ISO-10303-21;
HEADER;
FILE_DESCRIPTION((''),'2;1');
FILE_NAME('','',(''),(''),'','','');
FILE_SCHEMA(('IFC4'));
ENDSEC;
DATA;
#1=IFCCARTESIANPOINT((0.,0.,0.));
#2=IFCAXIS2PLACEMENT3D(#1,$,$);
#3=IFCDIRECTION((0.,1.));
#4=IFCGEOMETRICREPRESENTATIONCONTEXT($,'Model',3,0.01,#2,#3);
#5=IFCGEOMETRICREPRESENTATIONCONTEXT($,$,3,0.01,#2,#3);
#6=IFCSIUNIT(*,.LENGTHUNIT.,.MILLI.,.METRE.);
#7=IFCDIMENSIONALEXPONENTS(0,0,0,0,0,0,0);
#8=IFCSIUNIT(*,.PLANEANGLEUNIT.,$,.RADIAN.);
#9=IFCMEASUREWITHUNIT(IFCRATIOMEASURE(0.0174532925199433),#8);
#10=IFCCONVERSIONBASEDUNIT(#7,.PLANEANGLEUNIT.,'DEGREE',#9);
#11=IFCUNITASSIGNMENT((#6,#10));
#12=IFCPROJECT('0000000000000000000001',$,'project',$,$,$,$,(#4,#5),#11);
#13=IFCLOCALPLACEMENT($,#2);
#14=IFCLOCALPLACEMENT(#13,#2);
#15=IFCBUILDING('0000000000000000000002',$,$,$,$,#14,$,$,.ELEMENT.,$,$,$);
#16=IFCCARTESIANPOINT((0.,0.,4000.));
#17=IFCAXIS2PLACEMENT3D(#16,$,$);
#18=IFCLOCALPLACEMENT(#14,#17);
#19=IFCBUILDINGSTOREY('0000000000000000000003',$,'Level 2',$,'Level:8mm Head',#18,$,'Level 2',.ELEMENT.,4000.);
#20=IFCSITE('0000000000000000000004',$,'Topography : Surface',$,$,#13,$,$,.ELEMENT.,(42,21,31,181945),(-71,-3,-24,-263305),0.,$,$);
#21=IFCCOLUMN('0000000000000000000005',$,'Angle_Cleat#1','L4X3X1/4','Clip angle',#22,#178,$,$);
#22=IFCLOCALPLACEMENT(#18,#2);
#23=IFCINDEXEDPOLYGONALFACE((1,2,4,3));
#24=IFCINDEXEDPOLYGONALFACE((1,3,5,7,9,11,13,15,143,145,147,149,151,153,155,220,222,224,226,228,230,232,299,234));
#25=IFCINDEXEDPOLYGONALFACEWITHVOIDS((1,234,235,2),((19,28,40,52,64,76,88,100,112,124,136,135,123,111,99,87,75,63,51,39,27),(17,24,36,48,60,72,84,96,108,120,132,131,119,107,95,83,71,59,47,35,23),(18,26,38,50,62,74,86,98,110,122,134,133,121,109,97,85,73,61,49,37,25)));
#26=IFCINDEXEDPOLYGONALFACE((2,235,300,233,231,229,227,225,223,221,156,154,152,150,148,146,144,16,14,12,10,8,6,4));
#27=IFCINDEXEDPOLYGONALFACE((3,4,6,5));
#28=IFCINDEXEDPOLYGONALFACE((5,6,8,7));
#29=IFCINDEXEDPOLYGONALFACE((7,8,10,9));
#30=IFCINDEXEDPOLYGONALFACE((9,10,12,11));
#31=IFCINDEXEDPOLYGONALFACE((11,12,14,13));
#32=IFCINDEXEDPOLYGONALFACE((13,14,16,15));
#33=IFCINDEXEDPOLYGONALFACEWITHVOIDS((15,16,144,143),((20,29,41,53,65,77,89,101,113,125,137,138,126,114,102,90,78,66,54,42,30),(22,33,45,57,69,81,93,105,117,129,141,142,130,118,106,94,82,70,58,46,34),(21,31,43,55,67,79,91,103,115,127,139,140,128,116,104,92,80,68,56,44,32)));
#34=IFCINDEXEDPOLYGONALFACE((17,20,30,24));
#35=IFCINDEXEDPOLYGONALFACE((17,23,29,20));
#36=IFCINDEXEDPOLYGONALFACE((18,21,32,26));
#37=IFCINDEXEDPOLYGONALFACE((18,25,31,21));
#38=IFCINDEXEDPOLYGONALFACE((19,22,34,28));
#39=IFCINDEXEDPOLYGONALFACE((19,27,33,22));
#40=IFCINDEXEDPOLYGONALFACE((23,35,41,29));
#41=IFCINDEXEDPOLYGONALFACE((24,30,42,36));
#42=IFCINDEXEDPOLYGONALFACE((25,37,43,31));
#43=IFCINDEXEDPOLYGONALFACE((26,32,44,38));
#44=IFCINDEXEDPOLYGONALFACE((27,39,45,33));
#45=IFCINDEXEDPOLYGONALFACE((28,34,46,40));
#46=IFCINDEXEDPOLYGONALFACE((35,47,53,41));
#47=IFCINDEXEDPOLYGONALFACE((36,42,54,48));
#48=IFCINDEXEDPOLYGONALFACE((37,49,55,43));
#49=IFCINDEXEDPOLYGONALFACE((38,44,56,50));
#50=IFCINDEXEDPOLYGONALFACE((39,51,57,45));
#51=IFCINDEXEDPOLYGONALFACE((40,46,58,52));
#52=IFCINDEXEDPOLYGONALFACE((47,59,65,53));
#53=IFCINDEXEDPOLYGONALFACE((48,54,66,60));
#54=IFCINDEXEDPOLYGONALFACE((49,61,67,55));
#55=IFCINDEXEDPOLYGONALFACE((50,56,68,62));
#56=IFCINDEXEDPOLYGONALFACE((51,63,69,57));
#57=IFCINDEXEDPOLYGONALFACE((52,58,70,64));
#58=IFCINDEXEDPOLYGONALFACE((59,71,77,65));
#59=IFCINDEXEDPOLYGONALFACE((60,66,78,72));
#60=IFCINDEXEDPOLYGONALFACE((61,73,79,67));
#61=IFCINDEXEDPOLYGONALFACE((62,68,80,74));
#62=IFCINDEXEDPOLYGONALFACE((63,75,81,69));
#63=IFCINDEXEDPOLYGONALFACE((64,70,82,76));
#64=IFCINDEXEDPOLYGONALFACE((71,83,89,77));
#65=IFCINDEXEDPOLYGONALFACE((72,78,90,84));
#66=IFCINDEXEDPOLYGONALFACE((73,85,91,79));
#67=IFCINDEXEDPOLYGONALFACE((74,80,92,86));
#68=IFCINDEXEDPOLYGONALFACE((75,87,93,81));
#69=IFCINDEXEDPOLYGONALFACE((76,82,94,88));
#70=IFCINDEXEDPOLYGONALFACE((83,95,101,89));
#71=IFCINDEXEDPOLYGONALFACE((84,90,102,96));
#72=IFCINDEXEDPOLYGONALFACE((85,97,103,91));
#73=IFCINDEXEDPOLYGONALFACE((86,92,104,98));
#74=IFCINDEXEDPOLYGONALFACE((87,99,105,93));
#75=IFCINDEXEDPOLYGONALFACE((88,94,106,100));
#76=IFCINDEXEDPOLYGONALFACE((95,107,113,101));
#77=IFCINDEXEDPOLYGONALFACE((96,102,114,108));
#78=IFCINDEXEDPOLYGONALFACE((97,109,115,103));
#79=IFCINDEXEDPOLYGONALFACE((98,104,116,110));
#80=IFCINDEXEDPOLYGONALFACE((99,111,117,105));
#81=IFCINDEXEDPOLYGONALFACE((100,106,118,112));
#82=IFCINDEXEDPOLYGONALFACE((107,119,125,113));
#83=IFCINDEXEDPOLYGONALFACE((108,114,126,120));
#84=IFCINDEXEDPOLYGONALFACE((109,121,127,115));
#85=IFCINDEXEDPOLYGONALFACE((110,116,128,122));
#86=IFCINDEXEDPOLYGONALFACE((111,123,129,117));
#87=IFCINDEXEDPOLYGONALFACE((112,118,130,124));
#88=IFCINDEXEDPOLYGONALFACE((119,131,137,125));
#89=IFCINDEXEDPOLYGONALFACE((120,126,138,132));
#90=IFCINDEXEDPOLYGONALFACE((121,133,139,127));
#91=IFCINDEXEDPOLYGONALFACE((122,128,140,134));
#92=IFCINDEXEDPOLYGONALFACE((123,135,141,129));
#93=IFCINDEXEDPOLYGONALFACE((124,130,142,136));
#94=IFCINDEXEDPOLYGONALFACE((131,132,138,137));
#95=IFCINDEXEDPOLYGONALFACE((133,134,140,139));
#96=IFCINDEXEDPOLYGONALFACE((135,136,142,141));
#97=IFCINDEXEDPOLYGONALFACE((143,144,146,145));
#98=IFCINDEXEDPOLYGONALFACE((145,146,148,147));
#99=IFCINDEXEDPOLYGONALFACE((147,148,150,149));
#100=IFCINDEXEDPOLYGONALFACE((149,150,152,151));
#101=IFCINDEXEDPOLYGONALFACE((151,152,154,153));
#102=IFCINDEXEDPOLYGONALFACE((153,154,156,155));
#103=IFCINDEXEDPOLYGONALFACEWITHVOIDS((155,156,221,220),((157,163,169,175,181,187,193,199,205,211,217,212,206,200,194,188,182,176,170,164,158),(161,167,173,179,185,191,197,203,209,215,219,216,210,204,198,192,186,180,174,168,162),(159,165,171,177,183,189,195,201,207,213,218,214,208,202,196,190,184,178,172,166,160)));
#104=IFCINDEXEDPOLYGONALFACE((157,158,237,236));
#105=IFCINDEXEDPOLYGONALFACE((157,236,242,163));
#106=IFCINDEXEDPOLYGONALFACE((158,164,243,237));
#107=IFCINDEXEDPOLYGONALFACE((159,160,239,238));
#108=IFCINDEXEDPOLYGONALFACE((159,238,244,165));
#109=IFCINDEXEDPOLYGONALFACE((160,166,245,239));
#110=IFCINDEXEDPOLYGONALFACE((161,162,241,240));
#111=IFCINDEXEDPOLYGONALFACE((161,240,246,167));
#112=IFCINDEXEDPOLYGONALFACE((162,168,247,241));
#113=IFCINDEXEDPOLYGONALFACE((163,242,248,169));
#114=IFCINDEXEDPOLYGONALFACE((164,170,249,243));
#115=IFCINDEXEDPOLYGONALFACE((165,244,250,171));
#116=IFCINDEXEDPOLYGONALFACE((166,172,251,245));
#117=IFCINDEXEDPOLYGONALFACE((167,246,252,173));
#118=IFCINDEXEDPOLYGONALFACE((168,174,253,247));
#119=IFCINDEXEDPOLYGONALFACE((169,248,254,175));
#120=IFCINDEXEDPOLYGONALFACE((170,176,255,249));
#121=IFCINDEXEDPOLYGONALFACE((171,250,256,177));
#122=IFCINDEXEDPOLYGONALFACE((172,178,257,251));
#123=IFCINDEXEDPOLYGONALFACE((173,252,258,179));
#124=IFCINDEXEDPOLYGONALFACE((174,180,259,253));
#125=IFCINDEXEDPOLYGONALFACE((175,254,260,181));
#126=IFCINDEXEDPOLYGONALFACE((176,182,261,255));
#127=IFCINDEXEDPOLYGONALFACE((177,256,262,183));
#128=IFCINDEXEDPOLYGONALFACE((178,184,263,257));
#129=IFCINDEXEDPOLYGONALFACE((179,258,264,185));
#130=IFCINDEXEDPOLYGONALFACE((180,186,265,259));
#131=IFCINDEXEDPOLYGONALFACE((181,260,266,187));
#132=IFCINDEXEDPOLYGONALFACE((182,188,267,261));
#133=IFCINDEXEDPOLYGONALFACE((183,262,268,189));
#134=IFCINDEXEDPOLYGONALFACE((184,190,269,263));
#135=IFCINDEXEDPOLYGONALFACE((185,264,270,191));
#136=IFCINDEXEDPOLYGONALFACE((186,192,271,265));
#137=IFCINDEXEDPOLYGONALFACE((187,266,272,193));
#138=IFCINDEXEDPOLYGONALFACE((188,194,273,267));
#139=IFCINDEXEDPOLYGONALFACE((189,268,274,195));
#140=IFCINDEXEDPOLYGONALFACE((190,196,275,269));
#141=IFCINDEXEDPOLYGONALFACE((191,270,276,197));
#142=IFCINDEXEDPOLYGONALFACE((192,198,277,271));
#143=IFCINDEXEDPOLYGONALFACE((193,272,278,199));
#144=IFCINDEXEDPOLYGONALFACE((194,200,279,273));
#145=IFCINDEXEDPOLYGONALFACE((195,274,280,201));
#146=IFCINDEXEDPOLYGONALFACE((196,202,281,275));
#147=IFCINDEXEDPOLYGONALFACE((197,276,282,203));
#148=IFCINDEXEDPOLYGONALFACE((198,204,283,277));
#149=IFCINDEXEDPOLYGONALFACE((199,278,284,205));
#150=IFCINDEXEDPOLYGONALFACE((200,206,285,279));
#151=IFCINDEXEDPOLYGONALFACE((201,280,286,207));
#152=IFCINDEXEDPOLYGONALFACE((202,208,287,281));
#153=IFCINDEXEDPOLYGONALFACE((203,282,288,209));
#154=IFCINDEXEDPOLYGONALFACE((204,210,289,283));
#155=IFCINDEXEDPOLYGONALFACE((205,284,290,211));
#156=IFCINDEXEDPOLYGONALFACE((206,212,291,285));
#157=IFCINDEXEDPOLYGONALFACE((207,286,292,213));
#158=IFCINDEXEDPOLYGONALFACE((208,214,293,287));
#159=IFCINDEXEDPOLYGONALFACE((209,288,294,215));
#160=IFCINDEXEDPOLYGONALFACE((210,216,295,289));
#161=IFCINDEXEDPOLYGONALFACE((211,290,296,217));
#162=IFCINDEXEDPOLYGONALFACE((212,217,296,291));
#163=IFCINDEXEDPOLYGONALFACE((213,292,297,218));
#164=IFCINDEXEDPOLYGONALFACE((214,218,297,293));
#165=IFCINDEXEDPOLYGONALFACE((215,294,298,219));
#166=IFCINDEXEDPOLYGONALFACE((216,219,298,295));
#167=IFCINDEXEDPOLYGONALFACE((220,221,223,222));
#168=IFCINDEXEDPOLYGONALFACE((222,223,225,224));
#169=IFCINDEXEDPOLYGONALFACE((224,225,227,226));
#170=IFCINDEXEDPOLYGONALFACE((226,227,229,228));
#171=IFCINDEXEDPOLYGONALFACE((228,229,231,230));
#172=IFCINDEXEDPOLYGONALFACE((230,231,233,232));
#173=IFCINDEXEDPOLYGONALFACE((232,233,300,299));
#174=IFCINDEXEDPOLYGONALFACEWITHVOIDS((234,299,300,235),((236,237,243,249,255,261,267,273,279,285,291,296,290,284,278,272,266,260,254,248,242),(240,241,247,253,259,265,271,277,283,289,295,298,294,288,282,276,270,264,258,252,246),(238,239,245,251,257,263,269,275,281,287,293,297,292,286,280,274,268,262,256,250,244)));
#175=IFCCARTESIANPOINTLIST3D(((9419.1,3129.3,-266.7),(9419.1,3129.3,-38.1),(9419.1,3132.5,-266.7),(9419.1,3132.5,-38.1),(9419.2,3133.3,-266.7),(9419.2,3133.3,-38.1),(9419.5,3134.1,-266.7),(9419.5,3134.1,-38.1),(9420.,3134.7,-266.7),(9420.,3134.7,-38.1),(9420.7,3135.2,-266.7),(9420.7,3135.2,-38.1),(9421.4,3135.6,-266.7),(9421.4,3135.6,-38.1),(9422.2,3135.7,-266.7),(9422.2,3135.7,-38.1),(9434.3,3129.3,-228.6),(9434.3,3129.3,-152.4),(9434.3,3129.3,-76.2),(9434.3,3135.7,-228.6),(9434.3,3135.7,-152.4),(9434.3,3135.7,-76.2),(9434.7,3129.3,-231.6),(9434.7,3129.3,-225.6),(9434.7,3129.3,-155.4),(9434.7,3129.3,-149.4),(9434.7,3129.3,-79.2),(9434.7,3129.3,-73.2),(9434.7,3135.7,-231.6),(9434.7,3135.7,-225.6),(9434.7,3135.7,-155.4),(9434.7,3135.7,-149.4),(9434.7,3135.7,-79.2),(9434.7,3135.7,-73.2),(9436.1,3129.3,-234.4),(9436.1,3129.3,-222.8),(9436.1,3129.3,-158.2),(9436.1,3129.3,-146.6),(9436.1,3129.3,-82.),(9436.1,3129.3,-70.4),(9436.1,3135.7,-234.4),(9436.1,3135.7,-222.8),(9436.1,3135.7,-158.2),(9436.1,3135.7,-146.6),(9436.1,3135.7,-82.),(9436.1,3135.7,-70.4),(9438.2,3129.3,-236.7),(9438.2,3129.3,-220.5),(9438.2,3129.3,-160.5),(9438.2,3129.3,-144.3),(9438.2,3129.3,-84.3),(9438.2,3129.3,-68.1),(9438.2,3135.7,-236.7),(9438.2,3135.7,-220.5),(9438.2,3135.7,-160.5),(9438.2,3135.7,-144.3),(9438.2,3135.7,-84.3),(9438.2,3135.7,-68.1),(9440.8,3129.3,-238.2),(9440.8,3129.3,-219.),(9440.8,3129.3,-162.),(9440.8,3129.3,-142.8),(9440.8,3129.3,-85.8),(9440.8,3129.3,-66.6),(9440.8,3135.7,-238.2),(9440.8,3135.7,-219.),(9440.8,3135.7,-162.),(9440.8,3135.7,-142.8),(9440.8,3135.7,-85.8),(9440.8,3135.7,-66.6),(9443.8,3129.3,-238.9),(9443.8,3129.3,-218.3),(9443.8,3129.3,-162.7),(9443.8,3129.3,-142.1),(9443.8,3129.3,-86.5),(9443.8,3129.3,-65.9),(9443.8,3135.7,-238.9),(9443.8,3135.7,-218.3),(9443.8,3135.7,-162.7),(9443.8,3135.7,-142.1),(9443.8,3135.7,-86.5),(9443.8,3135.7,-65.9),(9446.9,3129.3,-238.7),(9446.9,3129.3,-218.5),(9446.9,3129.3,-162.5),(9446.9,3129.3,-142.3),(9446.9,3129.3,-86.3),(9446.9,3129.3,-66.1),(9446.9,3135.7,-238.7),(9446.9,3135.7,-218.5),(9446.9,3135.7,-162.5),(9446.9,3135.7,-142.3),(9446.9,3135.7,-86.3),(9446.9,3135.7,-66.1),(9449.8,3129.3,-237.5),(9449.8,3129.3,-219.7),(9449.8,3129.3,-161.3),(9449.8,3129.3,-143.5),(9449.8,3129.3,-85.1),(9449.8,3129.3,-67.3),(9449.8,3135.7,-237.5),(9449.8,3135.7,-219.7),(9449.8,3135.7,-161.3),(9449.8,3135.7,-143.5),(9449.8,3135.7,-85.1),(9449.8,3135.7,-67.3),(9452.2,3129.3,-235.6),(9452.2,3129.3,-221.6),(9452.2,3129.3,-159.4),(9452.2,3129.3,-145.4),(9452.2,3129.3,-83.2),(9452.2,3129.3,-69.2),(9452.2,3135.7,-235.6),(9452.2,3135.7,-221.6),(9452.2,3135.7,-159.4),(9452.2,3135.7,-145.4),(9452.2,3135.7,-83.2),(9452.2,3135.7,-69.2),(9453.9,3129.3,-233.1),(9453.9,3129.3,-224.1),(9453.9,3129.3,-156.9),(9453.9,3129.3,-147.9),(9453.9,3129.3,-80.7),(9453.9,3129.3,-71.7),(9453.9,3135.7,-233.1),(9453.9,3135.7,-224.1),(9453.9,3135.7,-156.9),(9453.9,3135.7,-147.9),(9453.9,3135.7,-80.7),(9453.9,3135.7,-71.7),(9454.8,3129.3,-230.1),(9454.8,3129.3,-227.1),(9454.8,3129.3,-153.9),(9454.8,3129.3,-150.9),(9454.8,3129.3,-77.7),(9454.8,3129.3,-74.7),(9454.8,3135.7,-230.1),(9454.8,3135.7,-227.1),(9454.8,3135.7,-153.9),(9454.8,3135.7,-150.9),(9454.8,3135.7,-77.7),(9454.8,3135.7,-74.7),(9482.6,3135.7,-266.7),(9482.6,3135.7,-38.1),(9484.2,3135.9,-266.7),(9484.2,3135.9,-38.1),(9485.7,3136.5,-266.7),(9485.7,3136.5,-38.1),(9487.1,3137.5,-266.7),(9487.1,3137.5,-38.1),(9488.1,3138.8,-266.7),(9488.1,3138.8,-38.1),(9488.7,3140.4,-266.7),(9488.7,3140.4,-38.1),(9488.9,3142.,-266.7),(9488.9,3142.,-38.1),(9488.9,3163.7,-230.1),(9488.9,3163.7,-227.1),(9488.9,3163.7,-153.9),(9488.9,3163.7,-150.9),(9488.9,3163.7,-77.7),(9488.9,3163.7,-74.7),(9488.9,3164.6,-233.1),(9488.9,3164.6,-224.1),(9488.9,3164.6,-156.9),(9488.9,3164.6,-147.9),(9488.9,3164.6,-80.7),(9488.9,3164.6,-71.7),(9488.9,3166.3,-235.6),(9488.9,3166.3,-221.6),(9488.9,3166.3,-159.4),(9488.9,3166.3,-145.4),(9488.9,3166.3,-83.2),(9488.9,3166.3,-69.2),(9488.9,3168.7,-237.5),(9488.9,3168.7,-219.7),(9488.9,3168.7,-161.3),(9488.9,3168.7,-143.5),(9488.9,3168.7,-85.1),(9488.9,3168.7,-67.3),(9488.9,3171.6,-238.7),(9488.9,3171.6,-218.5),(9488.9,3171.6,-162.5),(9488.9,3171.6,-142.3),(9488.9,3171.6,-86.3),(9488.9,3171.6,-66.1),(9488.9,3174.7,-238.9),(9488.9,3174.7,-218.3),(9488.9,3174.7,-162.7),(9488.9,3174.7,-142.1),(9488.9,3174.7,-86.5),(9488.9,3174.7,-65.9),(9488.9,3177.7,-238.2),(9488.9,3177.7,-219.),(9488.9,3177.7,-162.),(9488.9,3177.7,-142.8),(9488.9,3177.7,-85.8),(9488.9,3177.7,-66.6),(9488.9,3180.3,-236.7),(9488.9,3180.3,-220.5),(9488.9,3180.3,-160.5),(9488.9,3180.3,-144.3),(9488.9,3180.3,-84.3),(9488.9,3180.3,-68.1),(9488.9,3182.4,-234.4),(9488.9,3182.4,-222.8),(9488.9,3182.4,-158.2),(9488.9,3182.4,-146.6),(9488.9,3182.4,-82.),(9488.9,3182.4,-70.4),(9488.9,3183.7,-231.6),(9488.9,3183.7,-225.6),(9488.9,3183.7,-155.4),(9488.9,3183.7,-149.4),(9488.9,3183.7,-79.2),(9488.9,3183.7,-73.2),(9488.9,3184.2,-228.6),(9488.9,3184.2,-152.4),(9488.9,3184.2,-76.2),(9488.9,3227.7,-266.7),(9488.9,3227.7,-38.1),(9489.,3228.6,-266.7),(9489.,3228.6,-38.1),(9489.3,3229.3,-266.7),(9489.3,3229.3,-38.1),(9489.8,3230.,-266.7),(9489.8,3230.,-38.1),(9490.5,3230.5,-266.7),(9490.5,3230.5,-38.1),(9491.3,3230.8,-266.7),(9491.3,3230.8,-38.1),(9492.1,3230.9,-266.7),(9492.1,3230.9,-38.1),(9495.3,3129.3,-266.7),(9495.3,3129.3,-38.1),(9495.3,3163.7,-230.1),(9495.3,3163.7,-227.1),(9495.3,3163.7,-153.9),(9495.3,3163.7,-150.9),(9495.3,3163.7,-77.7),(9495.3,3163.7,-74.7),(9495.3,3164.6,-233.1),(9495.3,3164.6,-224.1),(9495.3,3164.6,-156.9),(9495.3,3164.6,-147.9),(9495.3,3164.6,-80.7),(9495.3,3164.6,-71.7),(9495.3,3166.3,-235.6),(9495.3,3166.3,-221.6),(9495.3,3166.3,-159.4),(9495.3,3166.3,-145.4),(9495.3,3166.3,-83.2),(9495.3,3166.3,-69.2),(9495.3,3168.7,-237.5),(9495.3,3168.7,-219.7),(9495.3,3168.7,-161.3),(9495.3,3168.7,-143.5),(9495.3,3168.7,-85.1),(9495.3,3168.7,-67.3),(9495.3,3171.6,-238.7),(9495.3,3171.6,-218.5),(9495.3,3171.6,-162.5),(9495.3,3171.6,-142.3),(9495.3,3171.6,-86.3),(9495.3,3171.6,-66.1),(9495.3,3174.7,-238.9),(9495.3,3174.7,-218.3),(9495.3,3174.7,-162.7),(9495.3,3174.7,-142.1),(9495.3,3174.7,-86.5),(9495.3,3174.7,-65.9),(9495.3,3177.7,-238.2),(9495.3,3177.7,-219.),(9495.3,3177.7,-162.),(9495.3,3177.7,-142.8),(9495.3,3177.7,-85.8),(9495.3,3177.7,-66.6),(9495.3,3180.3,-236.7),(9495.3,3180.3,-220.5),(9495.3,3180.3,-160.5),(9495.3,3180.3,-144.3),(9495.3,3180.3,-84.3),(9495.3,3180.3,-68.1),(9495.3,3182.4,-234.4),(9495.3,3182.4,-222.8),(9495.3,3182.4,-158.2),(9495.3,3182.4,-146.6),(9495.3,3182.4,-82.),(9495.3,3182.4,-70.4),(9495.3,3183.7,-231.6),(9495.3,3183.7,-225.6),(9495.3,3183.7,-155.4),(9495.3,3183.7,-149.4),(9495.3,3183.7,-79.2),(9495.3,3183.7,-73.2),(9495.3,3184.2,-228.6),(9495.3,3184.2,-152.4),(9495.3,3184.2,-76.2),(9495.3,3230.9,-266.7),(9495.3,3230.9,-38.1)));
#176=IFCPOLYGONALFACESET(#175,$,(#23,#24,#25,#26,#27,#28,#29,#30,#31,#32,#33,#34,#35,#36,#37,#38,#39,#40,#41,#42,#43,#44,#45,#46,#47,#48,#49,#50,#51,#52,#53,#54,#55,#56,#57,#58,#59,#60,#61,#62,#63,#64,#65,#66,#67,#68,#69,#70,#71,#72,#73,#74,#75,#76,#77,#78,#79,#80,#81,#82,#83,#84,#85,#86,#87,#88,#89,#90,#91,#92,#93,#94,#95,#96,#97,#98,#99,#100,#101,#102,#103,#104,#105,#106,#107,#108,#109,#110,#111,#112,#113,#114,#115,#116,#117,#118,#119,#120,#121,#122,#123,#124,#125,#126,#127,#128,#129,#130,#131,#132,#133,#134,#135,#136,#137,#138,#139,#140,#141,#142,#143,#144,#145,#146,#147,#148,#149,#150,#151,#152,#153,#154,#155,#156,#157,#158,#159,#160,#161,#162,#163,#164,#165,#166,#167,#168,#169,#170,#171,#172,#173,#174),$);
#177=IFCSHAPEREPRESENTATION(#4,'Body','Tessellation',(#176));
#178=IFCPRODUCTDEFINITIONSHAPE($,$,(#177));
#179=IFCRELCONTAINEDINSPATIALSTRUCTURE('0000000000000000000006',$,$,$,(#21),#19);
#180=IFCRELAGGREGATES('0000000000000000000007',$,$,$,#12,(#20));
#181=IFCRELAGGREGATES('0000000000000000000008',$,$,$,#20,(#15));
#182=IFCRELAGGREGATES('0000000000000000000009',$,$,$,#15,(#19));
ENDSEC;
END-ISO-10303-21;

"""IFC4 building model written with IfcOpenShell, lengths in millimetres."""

from ifc_helpers import new_model, entity, si_unit, converted_unit, direction, frame, frame_2d, origin, origin_2d_with_axis, place, context, project, spatial, circle, l_section, extrude, element, save


model = new_model("IFC4")

# Units and contexts
model_context = context("Model", 3, precision=0.01, world=origin(), true_north=direction((0.0, 1.0)))
context_of_model = context(None, 3, precision=0.01, world=origin(), true_north=direction((0.0, 1.0)))
ifc_project = project(units=[si_unit("LENGTHUNIT", "METRE", prefix="MILLI"), converted_unit("PLANEANGLEUNIT", "DEGREE", entity("IfcRatioMeasure", 0.0174532925199433), si_unit("PLANEANGLEUNIT", "RADIAN"), dimensions=[0, 0, 0, 0, 0, 0, 0])], contexts=[model_context, context_of_model])

# Site, building, storey
site_placement = place(None, origin())
site = spatial("IfcSite", under=ifc_project, at=site_placement, Name="Topography : Surface", CompositionType="ELEMENT", RefLatitude=(42, 21, 31, 181945), RefLongitude=(-71, -3, -24, -263305), RefElevation=0.0)
building_placement = place(site_placement, origin())
building = spatial("IfcBuilding", under=site, at=building_placement, CompositionType="ELEMENT")
storey_placement = place(building_placement, frame((0.0, 0.0, 4000.0)))
storey = spatial("IfcBuildingStorey", under=building, at=storey_placement, Name="Level 2", ObjectType="Level:8mm Head", LongName="Level 2", CompositionType="ELEMENT", Elevation=4000.0)

# Column, openings
column_1_placement = place(storey_placement, frame((9477.0, 3160.4, -266.7), z_axis=(0.0, 0.0, -1.0), x_axis=(-1.0, 0.0, 0.0)))
column_1 = element("IfcColumn", 1, at=column_1_placement, inside=storey, Name="Angle_Cleat#1", Description="L4X3X1/4", ObjectType="Clip angle", context=model_context, shape_type="SweptSolid", body=[
    extrude(l_section(Depth=101.6, Width=76.2, Thickness=6.3, FilletRadius=6.3, EdgeRadius=3.2, at=frame_2d((19.8, 19.7))), origin(), (0.0, 0.0, -1.0), 228.6),
])
opening_1_placement = place(column_1_placement, frame((32.4, -31.5, -114.3), z_axis=(0.0, 1.0, 0.0), x_axis=(1.0, 0.0, 0.0)))
element("IfcOpeningElement", 2, at=opening_1_placement, cuts=column_1, ObjectType="Opening", context=model_context, shape_type="SweptSolid", body=[
    extrude(circle(Radius=10.3, at=origin_2d_with_axis()), origin(), (0.0, 0.0, 1.0), 7.3),
])
opening_2_placement = place(column_1_placement, frame((32.4, -31.5, -114.3), z_axis=(0.0, 1.0, 0.0), x_axis=(1.0, 0.0, 0.0)))
element("IfcOpeningElement", 3, at=opening_2_placement, cuts=column_1, ObjectType="Opening", context=model_context, shape_type="SweptSolid", body=[
    extrude(circle(Radius=10.3, at=frame_2d((0.0, 76.2), x_axis=(1.0, 0.0))), origin(), (0.0, 0.0, 1.0), 7.3),
])
opening_3_placement = place(column_1_placement, frame((32.4, -31.5, -114.3), z_axis=(0.0, 1.0, 0.0), x_axis=(1.0, 0.0, 0.0)))
element("IfcOpeningElement", 4, at=opening_3_placement, cuts=column_1, ObjectType="Opening", context=model_context, shape_type="SweptSolid", body=[
    extrude(circle(Radius=10.3, at=frame_2d((0.0, -76.2), x_axis=(1.0, 0.0))), origin(), (0.0, 0.0, 1.0), 7.3),
])
opening_4_placement = place(column_1_placement, frame((-18.9, 13.5, -114.3), z_axis=(1.0, 0.0, 0.0), x_axis=(0.0, 1.0, 0.0)))
element("IfcOpeningElement", 5, at=opening_4_placement, cuts=column_1, ObjectType="Opening", context=model_context, shape_type="SweptSolid", body=[
    extrude(circle(Radius=10.3, at=origin_2d_with_axis()), origin(), (0.0, 0.0, 1.0), 7.3),
])
opening_5_placement = place(column_1_placement, frame((-18.9, 13.5, -114.3), z_axis=(1.0, 0.0, 0.0), x_axis=(0.0, 1.0, 0.0)))
element("IfcOpeningElement", 6, at=opening_5_placement, cuts=column_1, ObjectType="Opening", context=model_context, shape_type="SweptSolid", body=[
    extrude(circle(Radius=10.3, at=frame_2d((0.0, 76.2), x_axis=(1.0, 0.0))), origin(), (0.0, 0.0, 1.0), 7.3),
])
opening_6_placement = place(column_1_placement, frame((-18.9, 13.5, -114.3), z_axis=(1.0, 0.0, 0.0), x_axis=(0.0, 1.0, 0.0)))
element("IfcOpeningElement", 7, at=opening_6_placement, cuts=column_1, ObjectType="Opening", context=model_context, shape_type="SweptSolid", body=[
    extrude(circle(Radius=10.3, at=frame_2d((0.0, -76.2), x_axis=(1.0, 0.0))), origin(), (0.0, 0.0, 1.0), 7.3),
])

save(model, "model.ifc")
